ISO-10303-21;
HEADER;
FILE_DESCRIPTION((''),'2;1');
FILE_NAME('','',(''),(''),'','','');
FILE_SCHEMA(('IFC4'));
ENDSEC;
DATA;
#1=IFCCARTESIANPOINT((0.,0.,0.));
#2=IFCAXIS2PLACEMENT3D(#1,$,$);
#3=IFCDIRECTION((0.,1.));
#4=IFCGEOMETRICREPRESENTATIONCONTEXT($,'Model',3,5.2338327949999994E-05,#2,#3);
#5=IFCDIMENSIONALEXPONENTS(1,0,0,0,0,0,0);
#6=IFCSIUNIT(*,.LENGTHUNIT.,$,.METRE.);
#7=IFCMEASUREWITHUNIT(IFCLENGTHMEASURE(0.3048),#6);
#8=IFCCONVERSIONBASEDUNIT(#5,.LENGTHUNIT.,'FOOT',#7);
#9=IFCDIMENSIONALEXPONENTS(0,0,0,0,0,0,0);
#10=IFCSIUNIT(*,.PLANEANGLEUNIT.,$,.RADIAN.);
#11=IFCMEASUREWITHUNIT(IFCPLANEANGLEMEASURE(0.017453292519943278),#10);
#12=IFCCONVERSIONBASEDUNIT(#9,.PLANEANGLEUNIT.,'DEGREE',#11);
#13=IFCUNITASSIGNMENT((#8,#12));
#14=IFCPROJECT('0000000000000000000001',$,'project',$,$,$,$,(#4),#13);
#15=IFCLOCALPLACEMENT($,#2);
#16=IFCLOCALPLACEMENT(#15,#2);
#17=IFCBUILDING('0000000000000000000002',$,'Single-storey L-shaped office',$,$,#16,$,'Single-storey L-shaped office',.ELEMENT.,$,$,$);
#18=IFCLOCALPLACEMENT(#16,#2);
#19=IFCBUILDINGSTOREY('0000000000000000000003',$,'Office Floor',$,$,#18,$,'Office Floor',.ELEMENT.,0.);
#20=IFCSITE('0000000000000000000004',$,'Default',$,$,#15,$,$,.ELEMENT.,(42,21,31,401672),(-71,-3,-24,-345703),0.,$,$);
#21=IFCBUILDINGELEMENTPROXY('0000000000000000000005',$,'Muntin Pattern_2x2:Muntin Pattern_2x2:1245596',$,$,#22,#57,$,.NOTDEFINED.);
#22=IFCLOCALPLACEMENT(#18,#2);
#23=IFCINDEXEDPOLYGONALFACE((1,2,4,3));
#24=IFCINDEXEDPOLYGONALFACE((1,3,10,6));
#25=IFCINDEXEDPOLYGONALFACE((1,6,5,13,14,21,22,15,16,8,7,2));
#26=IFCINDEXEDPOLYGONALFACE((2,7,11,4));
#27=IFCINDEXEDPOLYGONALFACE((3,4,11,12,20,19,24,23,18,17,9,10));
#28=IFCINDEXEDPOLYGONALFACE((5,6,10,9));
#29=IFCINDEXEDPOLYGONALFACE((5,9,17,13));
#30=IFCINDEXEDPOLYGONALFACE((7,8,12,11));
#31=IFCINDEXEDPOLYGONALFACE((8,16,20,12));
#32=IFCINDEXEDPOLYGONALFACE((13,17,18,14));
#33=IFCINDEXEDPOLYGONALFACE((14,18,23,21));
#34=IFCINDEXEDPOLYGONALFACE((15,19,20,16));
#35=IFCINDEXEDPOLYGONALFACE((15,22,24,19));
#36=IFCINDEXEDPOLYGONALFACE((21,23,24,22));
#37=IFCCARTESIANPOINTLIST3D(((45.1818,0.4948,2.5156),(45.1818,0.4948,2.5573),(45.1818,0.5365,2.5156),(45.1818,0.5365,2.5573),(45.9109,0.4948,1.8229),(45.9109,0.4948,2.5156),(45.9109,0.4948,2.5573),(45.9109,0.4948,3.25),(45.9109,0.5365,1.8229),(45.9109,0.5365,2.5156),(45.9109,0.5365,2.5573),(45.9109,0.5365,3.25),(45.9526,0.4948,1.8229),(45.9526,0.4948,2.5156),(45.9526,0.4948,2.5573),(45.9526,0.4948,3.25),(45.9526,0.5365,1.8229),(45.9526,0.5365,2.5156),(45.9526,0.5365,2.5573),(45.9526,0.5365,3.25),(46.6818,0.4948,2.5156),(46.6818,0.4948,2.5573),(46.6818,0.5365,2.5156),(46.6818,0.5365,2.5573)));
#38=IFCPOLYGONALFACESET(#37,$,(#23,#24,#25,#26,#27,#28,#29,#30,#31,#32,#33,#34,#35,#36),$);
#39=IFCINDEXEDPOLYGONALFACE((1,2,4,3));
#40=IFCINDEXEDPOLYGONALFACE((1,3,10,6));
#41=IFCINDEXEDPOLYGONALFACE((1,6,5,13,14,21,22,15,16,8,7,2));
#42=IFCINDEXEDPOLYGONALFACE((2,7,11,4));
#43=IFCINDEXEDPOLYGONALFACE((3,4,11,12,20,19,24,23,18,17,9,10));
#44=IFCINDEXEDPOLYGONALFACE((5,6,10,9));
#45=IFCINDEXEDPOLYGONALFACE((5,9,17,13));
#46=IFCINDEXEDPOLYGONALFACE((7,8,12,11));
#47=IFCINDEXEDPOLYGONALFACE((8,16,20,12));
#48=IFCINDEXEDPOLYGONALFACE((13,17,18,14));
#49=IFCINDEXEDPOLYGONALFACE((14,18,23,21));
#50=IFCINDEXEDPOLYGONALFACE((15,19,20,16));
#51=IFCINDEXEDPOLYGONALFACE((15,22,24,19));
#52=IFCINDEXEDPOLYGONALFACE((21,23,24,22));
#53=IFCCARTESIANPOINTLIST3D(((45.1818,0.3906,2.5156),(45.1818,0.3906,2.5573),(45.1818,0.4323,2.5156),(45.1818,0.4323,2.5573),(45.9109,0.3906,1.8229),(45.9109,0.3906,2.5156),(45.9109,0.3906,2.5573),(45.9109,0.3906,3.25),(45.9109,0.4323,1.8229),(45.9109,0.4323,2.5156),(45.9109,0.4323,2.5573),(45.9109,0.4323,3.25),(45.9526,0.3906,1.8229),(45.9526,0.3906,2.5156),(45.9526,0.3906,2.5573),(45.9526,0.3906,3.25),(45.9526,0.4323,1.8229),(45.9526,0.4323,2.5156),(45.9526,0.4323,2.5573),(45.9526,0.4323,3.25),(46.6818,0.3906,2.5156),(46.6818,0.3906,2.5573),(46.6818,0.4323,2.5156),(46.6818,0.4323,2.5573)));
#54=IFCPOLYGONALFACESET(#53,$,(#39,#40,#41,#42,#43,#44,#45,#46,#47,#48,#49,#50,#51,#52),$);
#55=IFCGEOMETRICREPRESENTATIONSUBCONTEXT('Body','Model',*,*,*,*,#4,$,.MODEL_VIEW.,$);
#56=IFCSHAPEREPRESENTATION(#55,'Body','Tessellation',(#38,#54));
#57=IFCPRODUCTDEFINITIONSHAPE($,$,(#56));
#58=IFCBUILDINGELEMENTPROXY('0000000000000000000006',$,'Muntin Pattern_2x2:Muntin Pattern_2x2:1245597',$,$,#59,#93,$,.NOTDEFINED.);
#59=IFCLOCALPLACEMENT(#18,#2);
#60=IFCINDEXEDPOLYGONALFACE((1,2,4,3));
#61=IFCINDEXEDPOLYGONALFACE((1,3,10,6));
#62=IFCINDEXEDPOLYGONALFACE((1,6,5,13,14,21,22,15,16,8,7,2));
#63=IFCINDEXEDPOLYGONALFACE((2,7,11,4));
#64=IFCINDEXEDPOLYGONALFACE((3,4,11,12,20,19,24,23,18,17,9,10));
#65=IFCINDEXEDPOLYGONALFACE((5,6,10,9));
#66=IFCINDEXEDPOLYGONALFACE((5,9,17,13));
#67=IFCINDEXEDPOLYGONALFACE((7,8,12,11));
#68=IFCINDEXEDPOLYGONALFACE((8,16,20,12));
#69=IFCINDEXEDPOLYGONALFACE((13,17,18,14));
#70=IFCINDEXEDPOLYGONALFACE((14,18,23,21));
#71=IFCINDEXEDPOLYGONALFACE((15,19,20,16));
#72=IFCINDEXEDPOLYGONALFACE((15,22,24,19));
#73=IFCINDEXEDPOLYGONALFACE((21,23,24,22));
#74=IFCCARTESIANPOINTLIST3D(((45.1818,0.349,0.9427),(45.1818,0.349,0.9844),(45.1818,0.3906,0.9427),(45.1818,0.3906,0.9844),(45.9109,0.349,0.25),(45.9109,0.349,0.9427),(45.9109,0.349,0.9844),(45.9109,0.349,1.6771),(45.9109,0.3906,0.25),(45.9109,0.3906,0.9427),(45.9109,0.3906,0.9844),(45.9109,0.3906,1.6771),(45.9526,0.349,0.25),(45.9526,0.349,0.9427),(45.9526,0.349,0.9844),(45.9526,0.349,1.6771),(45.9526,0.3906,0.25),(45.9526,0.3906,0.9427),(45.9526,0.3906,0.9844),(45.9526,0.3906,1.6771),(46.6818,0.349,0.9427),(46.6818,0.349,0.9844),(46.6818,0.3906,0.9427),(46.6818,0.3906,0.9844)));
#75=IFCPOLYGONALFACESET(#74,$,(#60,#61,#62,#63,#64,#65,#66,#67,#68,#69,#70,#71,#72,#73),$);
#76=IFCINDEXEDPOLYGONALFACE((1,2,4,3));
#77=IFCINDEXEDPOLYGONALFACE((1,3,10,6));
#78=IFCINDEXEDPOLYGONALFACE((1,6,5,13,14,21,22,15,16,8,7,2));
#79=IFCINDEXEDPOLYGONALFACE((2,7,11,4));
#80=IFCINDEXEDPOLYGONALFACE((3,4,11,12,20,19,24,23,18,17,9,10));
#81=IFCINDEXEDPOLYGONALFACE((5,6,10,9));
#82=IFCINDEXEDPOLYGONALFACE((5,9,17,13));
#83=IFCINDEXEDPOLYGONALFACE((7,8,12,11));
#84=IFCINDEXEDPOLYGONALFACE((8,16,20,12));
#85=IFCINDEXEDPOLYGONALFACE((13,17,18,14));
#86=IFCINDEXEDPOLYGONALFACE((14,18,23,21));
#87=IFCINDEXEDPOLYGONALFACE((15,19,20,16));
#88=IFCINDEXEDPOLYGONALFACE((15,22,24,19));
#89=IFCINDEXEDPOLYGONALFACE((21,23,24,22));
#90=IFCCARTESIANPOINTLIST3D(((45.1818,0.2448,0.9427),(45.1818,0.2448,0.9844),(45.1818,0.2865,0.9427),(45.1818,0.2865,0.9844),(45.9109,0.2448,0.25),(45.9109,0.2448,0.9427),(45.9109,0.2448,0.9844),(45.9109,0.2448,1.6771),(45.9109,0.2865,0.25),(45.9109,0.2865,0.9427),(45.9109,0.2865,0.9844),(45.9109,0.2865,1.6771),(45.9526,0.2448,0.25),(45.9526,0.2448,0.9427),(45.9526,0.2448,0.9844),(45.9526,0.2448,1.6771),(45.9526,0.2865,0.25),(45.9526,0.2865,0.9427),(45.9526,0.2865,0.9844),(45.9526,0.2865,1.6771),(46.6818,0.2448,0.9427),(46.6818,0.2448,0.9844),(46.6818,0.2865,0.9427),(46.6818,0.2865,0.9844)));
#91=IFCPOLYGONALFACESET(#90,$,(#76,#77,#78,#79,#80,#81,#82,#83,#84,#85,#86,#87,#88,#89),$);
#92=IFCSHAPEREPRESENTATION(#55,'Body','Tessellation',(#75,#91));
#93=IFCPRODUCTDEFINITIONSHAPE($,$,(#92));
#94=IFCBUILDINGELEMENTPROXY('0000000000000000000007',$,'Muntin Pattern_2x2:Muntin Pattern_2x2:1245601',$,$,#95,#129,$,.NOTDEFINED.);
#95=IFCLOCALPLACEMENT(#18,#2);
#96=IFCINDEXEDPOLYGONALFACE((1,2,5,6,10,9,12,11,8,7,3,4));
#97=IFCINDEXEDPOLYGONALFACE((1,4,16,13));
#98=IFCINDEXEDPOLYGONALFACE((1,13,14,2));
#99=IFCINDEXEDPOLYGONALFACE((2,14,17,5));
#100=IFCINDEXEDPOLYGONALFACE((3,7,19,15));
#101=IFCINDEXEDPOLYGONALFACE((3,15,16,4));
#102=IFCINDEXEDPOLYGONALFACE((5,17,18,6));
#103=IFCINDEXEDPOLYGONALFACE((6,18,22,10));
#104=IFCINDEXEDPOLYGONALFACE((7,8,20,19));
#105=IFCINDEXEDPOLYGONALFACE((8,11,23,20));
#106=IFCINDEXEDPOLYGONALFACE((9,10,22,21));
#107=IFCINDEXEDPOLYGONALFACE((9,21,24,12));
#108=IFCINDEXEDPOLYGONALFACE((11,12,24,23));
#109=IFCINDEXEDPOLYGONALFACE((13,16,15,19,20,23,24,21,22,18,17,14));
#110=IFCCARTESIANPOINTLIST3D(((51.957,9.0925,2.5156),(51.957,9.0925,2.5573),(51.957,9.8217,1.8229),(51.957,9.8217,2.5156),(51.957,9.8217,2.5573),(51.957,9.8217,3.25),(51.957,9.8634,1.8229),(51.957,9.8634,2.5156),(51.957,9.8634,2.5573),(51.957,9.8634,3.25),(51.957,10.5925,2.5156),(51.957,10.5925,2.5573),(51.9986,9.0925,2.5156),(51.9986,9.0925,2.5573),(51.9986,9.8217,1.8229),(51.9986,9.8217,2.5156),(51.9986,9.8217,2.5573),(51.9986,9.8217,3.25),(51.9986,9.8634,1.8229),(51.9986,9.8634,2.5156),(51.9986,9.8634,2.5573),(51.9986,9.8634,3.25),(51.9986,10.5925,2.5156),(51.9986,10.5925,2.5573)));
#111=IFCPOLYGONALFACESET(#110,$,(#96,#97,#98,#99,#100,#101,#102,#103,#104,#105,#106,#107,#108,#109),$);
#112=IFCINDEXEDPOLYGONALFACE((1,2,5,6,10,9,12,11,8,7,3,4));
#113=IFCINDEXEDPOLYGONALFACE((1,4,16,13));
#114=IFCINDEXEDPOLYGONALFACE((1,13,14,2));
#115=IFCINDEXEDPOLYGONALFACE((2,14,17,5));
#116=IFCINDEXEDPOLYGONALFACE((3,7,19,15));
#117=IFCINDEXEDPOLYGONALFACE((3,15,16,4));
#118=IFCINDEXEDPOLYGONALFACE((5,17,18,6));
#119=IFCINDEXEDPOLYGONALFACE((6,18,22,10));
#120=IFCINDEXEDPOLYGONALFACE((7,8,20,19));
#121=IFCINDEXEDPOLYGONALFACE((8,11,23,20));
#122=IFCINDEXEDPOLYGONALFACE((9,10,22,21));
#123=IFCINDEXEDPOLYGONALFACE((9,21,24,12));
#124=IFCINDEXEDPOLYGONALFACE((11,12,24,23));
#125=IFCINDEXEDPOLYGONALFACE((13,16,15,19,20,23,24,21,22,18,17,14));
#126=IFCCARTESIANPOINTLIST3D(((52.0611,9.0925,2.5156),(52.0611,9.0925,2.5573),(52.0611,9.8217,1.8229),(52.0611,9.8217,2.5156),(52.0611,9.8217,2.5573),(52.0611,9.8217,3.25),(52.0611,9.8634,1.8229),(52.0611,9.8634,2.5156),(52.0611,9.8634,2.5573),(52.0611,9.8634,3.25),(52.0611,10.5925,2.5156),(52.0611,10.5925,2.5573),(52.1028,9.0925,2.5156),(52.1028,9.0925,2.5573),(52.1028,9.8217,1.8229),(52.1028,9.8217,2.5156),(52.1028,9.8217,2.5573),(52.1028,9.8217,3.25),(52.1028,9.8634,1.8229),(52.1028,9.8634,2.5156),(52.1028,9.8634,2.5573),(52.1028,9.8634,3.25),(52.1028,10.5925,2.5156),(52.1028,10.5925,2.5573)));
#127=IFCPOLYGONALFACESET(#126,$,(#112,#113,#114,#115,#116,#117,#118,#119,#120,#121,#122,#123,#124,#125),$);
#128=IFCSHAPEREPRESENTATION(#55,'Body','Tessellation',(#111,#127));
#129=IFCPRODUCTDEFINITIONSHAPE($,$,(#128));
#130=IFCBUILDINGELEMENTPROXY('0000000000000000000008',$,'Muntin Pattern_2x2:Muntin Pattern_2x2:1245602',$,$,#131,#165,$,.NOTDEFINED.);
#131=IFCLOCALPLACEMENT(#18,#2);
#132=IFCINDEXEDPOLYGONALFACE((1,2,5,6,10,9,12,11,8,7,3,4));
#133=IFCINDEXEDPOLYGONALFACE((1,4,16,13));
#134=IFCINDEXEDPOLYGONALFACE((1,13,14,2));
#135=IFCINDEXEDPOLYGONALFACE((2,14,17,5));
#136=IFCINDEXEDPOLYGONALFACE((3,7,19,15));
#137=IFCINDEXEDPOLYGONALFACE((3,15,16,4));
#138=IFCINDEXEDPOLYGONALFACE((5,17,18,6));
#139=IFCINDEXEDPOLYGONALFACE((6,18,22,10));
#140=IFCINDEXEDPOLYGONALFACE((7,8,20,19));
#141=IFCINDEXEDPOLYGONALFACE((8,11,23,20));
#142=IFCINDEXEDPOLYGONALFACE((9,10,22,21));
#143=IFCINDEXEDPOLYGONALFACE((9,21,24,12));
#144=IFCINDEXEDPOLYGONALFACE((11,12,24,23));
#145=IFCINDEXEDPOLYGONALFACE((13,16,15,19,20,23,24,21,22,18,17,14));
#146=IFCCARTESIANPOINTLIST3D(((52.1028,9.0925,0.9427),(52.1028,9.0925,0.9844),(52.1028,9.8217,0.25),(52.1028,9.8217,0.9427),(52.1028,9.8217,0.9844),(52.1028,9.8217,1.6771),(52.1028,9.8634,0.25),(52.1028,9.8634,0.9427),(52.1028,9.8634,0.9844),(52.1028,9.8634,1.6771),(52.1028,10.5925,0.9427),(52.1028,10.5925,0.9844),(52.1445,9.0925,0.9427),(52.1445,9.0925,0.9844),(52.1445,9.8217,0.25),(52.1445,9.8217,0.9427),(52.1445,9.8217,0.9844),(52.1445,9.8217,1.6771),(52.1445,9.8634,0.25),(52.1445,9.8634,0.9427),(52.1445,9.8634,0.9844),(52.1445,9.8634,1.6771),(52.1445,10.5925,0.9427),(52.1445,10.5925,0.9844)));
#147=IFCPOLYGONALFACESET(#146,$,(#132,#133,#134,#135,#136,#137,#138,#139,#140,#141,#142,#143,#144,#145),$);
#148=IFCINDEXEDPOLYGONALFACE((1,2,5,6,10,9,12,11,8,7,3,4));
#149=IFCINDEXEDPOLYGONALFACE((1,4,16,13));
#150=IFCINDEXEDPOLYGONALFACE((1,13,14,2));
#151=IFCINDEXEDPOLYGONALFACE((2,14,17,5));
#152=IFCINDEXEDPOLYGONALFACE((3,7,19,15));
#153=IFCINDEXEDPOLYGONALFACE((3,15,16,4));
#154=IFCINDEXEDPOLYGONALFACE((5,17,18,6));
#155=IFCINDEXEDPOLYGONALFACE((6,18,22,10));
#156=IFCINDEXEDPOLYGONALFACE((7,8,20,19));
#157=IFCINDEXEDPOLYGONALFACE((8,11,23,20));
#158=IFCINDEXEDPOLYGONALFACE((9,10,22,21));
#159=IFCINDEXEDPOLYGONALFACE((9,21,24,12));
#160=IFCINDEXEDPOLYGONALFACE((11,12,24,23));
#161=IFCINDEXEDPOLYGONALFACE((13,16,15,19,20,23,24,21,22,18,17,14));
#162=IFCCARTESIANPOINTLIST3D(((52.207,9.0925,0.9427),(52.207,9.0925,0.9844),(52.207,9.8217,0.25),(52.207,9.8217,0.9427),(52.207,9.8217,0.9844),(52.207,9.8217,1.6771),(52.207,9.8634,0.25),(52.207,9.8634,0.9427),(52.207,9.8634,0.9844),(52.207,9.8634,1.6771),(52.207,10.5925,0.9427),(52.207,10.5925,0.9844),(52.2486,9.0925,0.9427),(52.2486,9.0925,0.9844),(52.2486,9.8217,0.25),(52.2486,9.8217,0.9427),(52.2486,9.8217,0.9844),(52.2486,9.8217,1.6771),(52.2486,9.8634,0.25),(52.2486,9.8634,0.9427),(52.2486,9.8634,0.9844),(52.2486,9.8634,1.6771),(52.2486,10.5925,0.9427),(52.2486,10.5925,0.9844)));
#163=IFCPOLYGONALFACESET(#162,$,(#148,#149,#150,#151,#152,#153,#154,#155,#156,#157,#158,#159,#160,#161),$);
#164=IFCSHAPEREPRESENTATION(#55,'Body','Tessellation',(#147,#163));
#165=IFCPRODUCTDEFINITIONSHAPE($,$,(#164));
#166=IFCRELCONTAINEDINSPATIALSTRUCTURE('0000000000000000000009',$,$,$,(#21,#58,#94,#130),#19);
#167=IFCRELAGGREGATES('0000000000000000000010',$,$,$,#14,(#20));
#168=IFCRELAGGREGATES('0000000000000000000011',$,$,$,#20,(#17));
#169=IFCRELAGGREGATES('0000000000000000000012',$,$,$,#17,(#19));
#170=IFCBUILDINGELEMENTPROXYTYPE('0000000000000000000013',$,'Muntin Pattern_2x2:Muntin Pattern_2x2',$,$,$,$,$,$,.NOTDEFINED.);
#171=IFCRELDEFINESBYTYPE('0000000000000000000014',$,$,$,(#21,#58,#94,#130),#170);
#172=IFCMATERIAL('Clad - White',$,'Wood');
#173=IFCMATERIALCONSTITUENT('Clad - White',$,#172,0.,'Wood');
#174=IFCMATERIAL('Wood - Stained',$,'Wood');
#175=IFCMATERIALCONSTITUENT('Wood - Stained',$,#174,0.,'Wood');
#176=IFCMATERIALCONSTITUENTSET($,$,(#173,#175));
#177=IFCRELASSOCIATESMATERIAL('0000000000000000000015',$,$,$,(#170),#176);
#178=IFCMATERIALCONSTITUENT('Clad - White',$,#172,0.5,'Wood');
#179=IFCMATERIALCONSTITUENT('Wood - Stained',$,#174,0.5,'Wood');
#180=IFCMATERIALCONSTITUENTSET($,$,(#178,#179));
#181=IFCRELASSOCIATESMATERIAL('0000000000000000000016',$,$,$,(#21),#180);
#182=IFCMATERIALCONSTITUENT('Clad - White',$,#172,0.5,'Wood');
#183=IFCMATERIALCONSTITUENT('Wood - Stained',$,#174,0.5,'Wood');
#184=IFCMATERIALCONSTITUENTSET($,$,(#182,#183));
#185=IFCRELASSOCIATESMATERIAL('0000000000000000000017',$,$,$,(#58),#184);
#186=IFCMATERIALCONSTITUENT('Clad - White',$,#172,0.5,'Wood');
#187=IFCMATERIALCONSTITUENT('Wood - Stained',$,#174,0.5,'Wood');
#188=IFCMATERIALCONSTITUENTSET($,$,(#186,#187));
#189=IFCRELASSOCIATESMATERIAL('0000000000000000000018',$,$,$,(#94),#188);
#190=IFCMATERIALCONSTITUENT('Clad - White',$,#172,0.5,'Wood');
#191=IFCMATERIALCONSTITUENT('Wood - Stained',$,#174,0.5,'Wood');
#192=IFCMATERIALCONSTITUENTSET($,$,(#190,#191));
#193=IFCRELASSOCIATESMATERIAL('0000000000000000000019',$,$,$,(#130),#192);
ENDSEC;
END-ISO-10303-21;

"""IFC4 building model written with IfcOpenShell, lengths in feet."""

from ifc_helpers import new_model, entity, si_unit, converted_unit, direction, frame, origin, place, context, subcontext, project, spatial, indexed_curve, outline, extrude, source, transform, mapped, material, constituent, constituent_set, type_object, type_shapes, element, save


model = new_model("IFC4")

# Units and contexts
model_context = context("Model", 3, precision=5.2338327949999994e-05, world=origin(), true_north=direction((0.0, 1.0)))
body_context = subcontext(model_context, "Body", "Model", "MODEL_VIEW")
ifc_project = project(units=[converted_unit("LENGTHUNIT", "FOOT", entity("IfcLengthMeasure", 0.3048), si_unit("LENGTHUNIT", "METRE"), dimensions=[1, 0, 0, 0, 0, 0, 0]), converted_unit("PLANEANGLEUNIT", "DEGREE", entity("IfcPlaneAngleMeasure", 0.017453292519943278), si_unit("PLANEANGLEUNIT", "RADIAN"), dimensions=[0, 0, 0, 0, 0, 0, 0])], contexts=[model_context])

# Site, building, storey
site_placement = place(None, origin())
site = spatial("IfcSite", under=ifc_project, at=site_placement, Name="Default", CompositionType="ELEMENT", RefLatitude=(42, 21, 31, 401672), RefLongitude=(-71, -3, -24, -345703), RefElevation=0.0)
building_placement = place(site_placement, origin())
building = spatial("IfcBuilding", under=site, at=building_placement, Name="Single-storey L-shaped office", LongName="Single-storey L-shaped office", CompositionType="ELEMENT")
storey_placement = place(building_placement, origin())
storey = spatial("IfcBuildingStorey", under=building, at=storey_placement, Name="Office Floor", LongName="Office Floor", CompositionType="ELEMENT", Elevation=0.0)

# Shared definitions
ifc_material_1 = material(Name="Wood - Stained", Category="Wood")

# Building element proxies
ifc_material_2 = material(Name="Clad - White", Category="Wood")
ifc_constituent_1 = constituent(ifc_material_2, Name="Clad - White", Category="Wood", fraction=0.5)
ifc_constituent_2 = constituent(ifc_material_1, Name="Wood - Stained", Category="Wood", fraction=0.5)
ifc_constituent_set_1 = constituent_set(constituents=[ifc_constituent_1, ifc_constituent_2])
ifc_constituent_3 = constituent(ifc_material_2, Name="Clad - White", Category="Wood", fraction=0.0)
ifc_constituent_4 = constituent(ifc_material_1, Name="Wood - Stained", Category="Wood", fraction=0.0)
ifc_constituent_set_2 = constituent_set(constituents=[ifc_constituent_3, ifc_constituent_4])
building_element_proxy_type_1 = type_object("IfcBuildingElementProxyType", Name="Muntin Pattern_2x2:Muntin Pattern_2x2", PredefinedType="NOTDEFINED", material=ifc_constituent_set_2)
shared_shape_1 = source(origin(), body_context, "Body", "SweptSolid", [
    extrude(outline(indexed_curve([(0.0208, -0.0208), (0.7135, -0.0208), (0.7135, 0.0208), (0.0208, 0.0208), (0.0208, 0.75), (-0.0208, 0.75), (-0.0208, 0.0208), (-0.7135, 0.0208), (-0.7135, -0.0208), (-0.0208, -0.0208), (-0.0208, -0.75), (0.0208, -0.75), (0.0208, -0.0208)], self_intersect=False)), frame((0.0, 0.0312, 0.7135), z_axis=(0.0, 1.0, 0.0), x_axis=(0.0, 0.0, 1.0)), (0.0, 0.0, 1.0), 0.0417),
    extrude(outline(indexed_curve([(0.0208, -0.0208), (0.7135, -0.0208), (0.7135, 0.0208), (0.0208, 0.0208), (0.0208, 0.75), (-0.0208, 0.75), (-0.0208, 0.0208), (-0.7135, 0.0208), (-0.7135, -0.0208), (-0.0208, -0.0208), (-0.0208, -0.75), (0.0208, -0.75), (0.0208, -0.0208)], self_intersect=False)), frame((0.0, -0.0729, 0.7135), z_axis=(0.0, 1.0, 0.0), x_axis=(0.0, 0.0, 1.0)), (0.0, 0.0, 1.0), 0.0417),
])
type_shapes(building_element_proxy_type_1, [shared_shape_1])
proxy_1_placement = place(storey_placement, frame((45.9318, 0.4635, 1.8229)))
element("IfcBuildingElementProxy", 1, at=proxy_1_placement, inside=storey, type_object=building_element_proxy_type_1, material=ifc_constituent_set_1, Name="Muntin Pattern_2x2:Muntin Pattern_2x2:1245596", PredefinedType="NOTDEFINED", context=body_context, shape_type="MappedRepresentation", body=[
    mapped(shared_shape_1, transform((0.0, 0.0, 0.0), scale=1.0)),
])
ifc_constituent_5 = constituent(ifc_material_2, Name="Clad - White", Category="Wood", fraction=0.5)
ifc_constituent_6 = constituent(ifc_material_1, Name="Wood - Stained", Category="Wood", fraction=0.5)
ifc_constituent_set_3 = constituent_set(constituents=[ifc_constituent_5, ifc_constituent_6])
proxy_2_placement = place(storey_placement, frame((45.9318, 0.3177, 0.25)))
element("IfcBuildingElementProxy", 2, at=proxy_2_placement, inside=storey, type_object=building_element_proxy_type_1, material=ifc_constituent_set_3, Name="Muntin Pattern_2x2:Muntin Pattern_2x2:1245597", PredefinedType="NOTDEFINED", context=body_context, shape_type="MappedRepresentation", body=[
    mapped(shared_shape_1, transform((0.0, 0.0, 0.0), scale=1.0)),
])
ifc_constituent_7 = constituent(ifc_material_2, Name="Clad - White", Category="Wood", fraction=0.5)
ifc_constituent_8 = constituent(ifc_material_1, Name="Wood - Stained", Category="Wood", fraction=0.5)
ifc_constituent_set_4 = constituent_set(constituents=[ifc_constituent_7, ifc_constituent_8])
proxy_3_placement = place(storey_placement, frame((52.0299, 9.8425, 1.8229), z_axis=(0.0, 0.0, 1.0), x_axis=(0.0, 1.0, 0.0)))
element("IfcBuildingElementProxy", 3, at=proxy_3_placement, inside=storey, type_object=building_element_proxy_type_1, material=ifc_constituent_set_4, Name="Muntin Pattern_2x2:Muntin Pattern_2x2:1245601", PredefinedType="NOTDEFINED", context=body_context, shape_type="MappedRepresentation", body=[
    mapped(shared_shape_1, transform((0.0, 0.0, 0.0), scale=1.0)),
])
ifc_constituent_9 = constituent(ifc_material_2, Name="Clad - White", Category="Wood", fraction=0.5)
ifc_constituent_10 = constituent(ifc_material_1, Name="Wood - Stained", Category="Wood", fraction=0.5)
ifc_constituent_set_5 = constituent_set(constituents=[ifc_constituent_9, ifc_constituent_10])
proxy_4_placement = place(storey_placement, frame((52.1757, 9.8425, 0.25), z_axis=(0.0, 0.0, 1.0), x_axis=(0.0, 1.0, 0.0)))
element("IfcBuildingElementProxy", 4, at=proxy_4_placement, inside=storey, type_object=building_element_proxy_type_1, material=ifc_constituent_set_5, Name="Muntin Pattern_2x2:Muntin Pattern_2x2:1245602", PredefinedType="NOTDEFINED", context=body_context, shape_type="MappedRepresentation", body=[
    mapped(shared_shape_1, transform((0.0, 0.0, 0.0), scale=1.0)),
])

save(model, "model.ifc")
